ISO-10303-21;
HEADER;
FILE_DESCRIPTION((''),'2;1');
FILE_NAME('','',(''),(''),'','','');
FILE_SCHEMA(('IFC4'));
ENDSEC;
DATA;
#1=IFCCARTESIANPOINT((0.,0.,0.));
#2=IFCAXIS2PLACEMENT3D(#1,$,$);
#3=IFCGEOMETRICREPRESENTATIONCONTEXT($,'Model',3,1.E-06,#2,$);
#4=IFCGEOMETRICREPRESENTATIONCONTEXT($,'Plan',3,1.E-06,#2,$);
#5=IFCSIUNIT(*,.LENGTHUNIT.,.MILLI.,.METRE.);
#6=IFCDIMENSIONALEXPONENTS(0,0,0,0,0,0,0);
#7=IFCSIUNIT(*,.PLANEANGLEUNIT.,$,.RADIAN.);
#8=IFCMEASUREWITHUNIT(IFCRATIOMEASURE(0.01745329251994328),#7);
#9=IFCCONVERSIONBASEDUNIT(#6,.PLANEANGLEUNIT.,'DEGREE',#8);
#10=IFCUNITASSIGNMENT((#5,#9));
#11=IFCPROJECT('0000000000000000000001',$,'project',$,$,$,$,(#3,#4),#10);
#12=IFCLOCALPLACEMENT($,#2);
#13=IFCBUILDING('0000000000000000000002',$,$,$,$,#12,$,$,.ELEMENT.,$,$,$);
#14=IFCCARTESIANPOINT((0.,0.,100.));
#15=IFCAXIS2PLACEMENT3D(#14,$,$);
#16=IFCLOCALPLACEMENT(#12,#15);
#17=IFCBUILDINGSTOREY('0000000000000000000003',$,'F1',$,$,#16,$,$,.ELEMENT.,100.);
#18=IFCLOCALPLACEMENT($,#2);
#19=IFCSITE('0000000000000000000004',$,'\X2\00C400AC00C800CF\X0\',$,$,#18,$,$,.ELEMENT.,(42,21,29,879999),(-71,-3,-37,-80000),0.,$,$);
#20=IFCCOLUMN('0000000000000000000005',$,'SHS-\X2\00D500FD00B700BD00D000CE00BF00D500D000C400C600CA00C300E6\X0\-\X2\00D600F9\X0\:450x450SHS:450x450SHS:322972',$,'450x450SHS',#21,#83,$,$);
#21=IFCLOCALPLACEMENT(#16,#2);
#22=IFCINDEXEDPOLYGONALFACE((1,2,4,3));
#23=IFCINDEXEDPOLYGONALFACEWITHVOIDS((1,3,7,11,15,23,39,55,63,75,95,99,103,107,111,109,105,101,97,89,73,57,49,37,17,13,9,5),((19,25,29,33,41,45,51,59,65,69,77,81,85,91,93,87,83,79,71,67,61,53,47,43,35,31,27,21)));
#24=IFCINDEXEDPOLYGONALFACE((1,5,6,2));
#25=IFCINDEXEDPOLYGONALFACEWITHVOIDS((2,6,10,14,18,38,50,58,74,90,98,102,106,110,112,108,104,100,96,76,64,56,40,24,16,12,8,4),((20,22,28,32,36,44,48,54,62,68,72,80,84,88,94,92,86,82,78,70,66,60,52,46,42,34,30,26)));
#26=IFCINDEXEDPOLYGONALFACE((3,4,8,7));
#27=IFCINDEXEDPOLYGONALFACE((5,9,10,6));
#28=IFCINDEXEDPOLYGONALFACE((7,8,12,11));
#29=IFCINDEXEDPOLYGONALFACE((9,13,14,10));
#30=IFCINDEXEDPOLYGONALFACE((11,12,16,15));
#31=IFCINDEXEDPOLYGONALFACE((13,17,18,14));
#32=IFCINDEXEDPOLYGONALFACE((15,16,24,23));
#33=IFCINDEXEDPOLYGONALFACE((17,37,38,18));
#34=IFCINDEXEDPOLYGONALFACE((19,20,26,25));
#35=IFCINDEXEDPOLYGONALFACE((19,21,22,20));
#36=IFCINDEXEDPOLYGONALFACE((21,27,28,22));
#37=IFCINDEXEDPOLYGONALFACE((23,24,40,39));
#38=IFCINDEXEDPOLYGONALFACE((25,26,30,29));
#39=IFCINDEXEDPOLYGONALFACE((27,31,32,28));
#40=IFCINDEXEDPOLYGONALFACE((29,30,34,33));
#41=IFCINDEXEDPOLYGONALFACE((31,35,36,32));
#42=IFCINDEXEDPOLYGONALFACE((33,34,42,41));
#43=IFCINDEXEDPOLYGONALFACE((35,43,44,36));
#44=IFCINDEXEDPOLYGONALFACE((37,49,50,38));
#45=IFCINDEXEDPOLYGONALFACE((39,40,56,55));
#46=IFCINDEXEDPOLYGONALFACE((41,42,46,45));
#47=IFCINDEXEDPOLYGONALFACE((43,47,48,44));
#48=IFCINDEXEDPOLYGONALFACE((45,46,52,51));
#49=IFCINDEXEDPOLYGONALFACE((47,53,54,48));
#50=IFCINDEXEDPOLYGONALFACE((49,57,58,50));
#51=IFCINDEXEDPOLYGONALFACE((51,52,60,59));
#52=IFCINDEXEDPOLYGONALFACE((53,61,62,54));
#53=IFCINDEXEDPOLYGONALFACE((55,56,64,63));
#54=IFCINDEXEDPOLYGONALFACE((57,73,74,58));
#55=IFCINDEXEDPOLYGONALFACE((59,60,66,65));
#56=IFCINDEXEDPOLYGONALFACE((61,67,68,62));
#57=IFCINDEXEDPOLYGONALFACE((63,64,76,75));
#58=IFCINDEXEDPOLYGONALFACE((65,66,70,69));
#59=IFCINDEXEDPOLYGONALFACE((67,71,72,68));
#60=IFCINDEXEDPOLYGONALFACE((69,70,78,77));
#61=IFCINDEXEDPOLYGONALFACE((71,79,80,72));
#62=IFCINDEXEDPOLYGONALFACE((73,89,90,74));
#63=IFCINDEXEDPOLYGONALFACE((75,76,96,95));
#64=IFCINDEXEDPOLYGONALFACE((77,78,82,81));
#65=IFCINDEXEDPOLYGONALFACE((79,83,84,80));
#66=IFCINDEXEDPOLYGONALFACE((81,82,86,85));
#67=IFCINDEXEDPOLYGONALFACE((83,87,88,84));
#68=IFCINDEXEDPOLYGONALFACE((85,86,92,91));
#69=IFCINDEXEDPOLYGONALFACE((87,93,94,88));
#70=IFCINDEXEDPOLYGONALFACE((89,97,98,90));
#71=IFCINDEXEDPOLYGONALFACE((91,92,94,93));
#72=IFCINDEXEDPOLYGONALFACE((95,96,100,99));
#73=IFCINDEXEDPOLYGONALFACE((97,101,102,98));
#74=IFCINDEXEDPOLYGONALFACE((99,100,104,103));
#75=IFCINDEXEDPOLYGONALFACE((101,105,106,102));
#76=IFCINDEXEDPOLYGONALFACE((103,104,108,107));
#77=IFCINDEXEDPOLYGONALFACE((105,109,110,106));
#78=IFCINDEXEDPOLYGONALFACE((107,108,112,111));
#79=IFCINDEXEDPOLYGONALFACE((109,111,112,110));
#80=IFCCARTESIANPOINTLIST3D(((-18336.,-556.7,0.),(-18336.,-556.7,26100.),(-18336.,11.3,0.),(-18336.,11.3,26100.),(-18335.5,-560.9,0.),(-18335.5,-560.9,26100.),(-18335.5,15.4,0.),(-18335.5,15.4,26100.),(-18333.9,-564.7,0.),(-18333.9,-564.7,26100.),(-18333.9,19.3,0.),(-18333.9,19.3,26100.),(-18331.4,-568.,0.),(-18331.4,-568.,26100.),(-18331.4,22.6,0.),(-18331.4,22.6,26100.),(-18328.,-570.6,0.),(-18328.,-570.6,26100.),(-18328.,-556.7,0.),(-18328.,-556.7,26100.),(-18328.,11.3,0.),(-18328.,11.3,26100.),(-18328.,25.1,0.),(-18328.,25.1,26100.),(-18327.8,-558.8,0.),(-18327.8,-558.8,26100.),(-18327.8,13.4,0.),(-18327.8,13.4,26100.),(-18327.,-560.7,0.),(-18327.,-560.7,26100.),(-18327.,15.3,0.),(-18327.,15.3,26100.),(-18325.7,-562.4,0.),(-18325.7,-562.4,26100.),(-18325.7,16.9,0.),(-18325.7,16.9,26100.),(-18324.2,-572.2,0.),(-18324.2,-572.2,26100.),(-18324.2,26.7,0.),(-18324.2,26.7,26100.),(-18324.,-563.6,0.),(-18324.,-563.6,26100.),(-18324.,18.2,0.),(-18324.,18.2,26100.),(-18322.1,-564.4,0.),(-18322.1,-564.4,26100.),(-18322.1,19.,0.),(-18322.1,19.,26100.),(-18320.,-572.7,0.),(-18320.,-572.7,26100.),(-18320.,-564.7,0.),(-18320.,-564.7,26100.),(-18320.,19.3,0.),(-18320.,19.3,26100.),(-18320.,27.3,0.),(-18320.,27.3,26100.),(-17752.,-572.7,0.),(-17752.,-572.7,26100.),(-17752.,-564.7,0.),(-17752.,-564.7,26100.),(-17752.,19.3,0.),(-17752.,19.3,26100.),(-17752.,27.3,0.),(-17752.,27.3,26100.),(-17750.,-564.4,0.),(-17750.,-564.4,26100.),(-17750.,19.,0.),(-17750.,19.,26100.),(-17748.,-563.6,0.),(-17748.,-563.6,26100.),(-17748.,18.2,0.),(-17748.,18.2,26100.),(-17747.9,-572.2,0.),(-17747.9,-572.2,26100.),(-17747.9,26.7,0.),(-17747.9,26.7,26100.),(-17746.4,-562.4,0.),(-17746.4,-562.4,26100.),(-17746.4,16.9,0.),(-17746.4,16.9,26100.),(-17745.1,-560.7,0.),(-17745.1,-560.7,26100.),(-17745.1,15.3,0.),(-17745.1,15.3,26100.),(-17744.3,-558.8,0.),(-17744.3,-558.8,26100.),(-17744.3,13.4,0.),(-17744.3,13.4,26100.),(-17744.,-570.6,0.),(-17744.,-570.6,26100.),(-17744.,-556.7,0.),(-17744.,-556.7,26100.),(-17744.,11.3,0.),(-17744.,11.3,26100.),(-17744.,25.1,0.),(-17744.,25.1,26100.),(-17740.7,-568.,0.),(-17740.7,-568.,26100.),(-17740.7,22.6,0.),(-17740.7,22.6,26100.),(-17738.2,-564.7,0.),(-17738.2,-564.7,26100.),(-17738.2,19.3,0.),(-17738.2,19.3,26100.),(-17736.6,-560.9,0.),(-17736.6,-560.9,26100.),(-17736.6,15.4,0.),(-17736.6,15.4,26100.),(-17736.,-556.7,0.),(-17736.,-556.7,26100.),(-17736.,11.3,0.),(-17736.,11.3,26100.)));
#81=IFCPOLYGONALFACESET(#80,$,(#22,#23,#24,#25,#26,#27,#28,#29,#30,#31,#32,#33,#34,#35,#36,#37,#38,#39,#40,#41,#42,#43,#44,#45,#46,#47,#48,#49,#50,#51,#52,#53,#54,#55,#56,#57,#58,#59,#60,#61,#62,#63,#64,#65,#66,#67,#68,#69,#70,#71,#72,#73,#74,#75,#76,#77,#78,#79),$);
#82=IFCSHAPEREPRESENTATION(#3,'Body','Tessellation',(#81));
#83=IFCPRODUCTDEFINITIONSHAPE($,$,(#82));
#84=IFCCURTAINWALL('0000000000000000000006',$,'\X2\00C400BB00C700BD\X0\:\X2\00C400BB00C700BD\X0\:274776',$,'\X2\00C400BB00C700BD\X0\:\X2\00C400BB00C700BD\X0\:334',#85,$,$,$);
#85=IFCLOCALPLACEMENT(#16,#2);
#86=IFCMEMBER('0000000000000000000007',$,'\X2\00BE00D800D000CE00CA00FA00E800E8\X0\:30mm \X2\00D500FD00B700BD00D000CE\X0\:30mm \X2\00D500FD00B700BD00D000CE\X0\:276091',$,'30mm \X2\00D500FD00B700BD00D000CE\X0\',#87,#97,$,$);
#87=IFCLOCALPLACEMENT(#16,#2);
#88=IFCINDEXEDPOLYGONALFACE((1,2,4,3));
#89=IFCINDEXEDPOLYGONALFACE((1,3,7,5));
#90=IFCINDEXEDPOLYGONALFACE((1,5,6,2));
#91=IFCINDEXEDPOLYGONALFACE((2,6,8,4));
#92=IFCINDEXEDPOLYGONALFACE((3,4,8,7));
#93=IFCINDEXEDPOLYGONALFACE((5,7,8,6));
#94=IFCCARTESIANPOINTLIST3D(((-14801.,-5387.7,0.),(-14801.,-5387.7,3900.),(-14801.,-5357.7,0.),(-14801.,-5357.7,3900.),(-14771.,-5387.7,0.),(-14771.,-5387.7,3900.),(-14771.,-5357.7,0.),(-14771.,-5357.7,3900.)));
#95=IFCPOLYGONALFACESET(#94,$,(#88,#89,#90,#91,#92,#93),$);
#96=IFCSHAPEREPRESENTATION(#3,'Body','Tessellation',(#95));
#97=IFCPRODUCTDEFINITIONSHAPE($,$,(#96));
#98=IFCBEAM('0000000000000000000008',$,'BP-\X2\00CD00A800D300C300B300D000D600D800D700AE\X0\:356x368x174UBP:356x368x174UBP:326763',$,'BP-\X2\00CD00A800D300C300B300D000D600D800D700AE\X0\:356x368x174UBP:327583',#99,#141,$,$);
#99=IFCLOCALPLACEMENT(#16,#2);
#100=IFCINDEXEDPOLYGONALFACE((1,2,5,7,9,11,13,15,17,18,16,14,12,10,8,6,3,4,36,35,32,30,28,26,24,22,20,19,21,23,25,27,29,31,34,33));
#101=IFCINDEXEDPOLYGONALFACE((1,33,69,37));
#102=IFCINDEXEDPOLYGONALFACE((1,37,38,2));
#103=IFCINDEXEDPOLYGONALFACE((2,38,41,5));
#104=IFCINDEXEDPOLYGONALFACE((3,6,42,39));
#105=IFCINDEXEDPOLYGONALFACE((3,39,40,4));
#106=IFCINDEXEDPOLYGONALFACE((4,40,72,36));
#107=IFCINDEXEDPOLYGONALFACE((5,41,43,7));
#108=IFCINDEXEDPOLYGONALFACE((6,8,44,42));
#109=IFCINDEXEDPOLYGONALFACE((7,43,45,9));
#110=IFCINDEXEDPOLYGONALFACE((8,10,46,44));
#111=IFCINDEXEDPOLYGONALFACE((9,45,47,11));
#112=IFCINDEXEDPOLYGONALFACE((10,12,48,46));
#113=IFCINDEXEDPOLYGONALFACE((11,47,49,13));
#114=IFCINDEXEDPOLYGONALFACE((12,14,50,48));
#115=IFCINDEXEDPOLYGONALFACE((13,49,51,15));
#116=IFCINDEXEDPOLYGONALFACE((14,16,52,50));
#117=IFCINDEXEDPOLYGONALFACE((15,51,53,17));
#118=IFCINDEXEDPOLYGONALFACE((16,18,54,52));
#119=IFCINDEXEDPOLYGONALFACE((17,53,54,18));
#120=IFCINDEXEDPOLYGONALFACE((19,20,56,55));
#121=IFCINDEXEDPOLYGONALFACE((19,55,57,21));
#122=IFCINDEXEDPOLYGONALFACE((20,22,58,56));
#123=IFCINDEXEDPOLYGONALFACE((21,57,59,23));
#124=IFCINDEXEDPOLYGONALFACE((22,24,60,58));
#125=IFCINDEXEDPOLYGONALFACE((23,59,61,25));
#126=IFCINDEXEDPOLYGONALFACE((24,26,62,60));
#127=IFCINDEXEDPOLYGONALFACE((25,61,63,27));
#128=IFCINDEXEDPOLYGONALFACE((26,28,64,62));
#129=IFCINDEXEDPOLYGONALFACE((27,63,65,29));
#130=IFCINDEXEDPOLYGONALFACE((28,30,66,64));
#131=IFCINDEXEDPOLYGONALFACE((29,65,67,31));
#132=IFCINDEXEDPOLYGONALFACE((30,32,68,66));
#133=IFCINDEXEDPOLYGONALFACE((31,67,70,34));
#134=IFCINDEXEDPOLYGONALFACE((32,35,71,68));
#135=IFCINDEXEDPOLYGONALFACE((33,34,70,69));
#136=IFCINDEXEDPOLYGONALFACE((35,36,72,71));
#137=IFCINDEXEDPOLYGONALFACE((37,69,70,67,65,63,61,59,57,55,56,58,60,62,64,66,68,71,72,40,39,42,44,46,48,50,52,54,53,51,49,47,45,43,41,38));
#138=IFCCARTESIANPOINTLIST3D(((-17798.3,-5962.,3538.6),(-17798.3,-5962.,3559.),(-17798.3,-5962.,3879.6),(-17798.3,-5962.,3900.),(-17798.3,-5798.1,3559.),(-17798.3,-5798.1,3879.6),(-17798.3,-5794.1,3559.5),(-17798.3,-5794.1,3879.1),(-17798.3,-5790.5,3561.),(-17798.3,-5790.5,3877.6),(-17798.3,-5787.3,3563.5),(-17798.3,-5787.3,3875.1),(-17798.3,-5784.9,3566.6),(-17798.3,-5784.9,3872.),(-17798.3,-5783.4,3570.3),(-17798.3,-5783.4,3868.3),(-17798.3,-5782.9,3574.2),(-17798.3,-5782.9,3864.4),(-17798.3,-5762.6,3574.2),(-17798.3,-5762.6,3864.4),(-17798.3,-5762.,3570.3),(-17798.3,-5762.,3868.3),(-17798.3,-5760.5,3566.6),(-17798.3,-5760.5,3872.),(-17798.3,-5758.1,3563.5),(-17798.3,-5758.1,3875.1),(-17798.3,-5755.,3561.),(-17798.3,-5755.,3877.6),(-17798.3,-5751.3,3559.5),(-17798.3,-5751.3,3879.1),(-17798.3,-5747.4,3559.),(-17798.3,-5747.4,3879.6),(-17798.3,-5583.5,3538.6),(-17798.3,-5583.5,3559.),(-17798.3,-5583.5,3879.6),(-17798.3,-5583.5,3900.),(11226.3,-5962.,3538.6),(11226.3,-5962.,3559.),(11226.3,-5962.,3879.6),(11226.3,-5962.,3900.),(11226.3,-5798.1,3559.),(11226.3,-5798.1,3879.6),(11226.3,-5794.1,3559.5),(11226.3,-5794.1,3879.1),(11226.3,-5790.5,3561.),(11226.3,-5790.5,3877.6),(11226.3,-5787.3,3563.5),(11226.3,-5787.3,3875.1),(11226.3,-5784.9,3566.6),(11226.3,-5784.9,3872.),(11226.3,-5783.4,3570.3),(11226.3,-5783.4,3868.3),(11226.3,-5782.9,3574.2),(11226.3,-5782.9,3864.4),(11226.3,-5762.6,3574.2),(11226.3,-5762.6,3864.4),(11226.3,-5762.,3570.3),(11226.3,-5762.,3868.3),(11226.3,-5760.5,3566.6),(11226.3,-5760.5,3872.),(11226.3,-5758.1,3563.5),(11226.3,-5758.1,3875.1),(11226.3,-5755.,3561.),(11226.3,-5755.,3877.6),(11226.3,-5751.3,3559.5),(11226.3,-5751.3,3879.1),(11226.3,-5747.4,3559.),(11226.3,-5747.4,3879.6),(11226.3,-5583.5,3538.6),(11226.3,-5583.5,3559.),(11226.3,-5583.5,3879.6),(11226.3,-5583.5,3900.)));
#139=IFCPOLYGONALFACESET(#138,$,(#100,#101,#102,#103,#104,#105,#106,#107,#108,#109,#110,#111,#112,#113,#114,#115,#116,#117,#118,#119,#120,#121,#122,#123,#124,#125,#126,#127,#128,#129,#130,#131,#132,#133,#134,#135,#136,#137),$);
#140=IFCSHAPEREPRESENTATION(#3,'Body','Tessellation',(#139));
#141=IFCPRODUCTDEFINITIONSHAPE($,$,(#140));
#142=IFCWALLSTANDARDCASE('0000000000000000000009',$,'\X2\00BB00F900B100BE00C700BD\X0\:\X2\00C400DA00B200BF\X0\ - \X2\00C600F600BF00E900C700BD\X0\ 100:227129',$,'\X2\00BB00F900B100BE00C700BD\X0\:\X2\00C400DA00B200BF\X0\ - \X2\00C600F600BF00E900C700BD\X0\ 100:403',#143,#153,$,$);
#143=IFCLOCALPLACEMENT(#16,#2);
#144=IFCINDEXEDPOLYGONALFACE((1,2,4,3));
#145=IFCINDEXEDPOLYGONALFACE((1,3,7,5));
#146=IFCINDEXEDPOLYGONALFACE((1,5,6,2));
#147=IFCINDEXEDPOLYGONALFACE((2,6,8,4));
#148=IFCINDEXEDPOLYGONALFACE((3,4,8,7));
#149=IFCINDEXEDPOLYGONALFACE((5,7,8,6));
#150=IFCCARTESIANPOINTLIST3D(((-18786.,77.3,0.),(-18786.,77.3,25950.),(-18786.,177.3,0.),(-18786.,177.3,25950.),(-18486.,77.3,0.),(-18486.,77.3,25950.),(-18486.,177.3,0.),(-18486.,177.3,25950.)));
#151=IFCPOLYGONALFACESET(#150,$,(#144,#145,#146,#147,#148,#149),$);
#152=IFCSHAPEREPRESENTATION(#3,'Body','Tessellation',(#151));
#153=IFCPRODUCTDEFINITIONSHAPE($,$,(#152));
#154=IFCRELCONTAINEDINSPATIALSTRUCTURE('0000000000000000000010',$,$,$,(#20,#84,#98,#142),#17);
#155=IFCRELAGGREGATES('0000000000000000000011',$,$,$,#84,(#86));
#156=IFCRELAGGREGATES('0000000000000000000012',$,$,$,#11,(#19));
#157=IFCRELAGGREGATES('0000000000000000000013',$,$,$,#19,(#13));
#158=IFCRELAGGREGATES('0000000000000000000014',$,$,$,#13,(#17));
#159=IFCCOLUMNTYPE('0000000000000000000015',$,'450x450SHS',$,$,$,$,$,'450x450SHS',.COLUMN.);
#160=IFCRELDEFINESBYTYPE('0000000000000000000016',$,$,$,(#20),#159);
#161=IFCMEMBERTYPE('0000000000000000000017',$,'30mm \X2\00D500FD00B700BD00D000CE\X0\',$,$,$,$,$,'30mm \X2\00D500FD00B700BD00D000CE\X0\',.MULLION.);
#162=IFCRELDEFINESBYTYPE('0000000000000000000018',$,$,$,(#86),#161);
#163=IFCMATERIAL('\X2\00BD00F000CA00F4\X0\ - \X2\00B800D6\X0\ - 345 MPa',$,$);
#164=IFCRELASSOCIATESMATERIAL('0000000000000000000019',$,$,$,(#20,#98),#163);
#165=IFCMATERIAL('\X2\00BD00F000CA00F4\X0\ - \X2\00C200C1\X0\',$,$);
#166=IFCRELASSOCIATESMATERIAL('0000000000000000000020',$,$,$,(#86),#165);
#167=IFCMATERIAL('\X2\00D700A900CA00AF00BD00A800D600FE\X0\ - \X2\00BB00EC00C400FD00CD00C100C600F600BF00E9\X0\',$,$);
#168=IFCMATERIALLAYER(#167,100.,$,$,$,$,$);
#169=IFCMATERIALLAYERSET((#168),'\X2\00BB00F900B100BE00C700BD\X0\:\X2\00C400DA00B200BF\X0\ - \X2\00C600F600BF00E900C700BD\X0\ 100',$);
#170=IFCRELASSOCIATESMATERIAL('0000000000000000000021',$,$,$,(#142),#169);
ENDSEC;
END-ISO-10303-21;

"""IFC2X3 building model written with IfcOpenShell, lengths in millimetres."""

from ifc_helpers import new_model, entity, si_unit, converted_unit, frame, frame_2d, origin, origin_2d_with_axis, place, context, project, spatial, polyline, circle_curve, parameter, trimmed, segment, composite_curve, rectangle, outline, extrude, clip, bounded_halfspace, source, transform, mapped, material, layer, layer_set, layer_usage, type_object, type_shapes, element, aggregate, save


model = new_model("IFC2X3")

# Units and contexts
model_context = context("Model", 3, precision=1e-06, world=origin())
plan_context = context("Plan", 3, precision=1e-06, world=origin())
ifc_project = project(units=[si_unit("LENGTHUNIT", "METRE", prefix="MILLI"), converted_unit("PLANEANGLEUNIT", "DEGREE", entity("IfcRatioMeasure", 0.01745329251994328), si_unit("PLANEANGLEUNIT", "RADIAN"), dimensions=[0, 0, 0, 0, 0, 0, 0])], contexts=[model_context, plan_context])

# Site, building, storey
site_placement = place(None, origin())
site = spatial("IfcSite", under=ifc_project, at=site_placement, Name="Ä¬ÈÏ", CompositionType="ELEMENT", RefLatitude=(42, 21, 29, 879999), RefLongitude=(-71, -3, -37, -80000), RefElevation=0.0)
building_placement = place(None, origin())
building = spatial("IfcBuilding", under=site, at=building_placement, CompositionType="ELEMENT")
storey_placement = place(building_placement, frame((0.0, 0.0, 100.0)))
storey = spatial("IfcBuildingStorey", under=building, at=storey_placement, Name="F1", CompositionType="ELEMENT", Elevation=100.0)

# Column
ifc_material_1 = material(Name="½ðÊô - ¸Ö - 345 MPa")
column_type_1 = type_object("IfcColumnType", Name="450x450SHS", ElementType="450x450SHS", PredefinedType="COLUMN")
shared_shape_1 = source(origin(), model_context, "Body", "SweptSolid", [
    extrude(outline(composite_curve([segment(polyline([(-284.0, -300.0), (284.0, -300.0)]), True, "CONTINUOUS"), segment(trimmed(circle_curve(frame_2d((284.0, -284.0), x_axis=(-1.0, 0.0)), 16.0), [parameter(90.0)], [parameter(180.0)], True, "PARAMETER"), True, "CONTINUOUS"), segment(polyline([(300.0, -284.0), (300.0, 284.0)]), True, "CONTINUOUS"), segment(trimmed(circle_curve(frame_2d((284.0, 284.0), x_axis=(-1.0, 0.0)), 16.0), [parameter(180.0)], [parameter(270.0)], True, "PARAMETER"), True, "CONTINUOUS"), segment(polyline([(284.0, 300.0), (-284.0, 300.0)]), True, "CONTINUOUS"), segment(trimmed(circle_curve(frame_2d((-284.0, 284.0), x_axis=(-1.0, 0.0)), 16.0), [parameter(270.0)], [parameter(360.0)], True, "PARAMETER"), True, "CONTINUOUS"), segment(polyline([(-300.0, 284.0), (-300.0, -284.0)]), True, "CONTINUOUS"), segment(trimmed(circle_curve(frame_2d((-284.0, -284.0), x_axis=(-1.0, 0.0)), 16.0), [parameter(360.0)], [parameter(90.0)], True, "PARAMETER"), True, "CONTINUOUS")], self_intersect=False), holes=[composite_curve([segment(trimmed(circle_curve(frame_2d((-284.0, -284.0), x_axis=(-1.0, 0.0)), 8.0), [parameter(0.0)], [parameter(90.0)], True, "PARAMETER"), False, "CONTINUOUS"), segment(polyline([(-292.0, -284.0), (-292.0, 284.0)]), True, "CONTINUOUS"), segment(trimmed(circle_curve(frame_2d((-284.0, 284.0), x_axis=(-1.0, 0.0)), 8.0), [parameter(270.0)], [parameter(360.0)], True, "PARAMETER"), False, "CONTINUOUS"), segment(polyline([(-284.0, 292.0), (284.0, 292.0)]), True, "CONTINUOUS"), segment(trimmed(circle_curve(frame_2d((284.0, 284.0), x_axis=(-1.0, 0.0)), 8.0), [parameter(180.0)], [parameter(270.0)], True, "PARAMETER"), False, "CONTINUOUS"), segment(polyline([(292.0, 284.0), (292.0, -284.0)]), True, "CONTINUOUS"), segment(trimmed(circle_curve(frame_2d((284.0, -284.0), x_axis=(-1.0, 0.0)), 8.0), [parameter(90.0)], [parameter(180.0)], True, "PARAMETER"), False, "CONTINUOUS"), segment(polyline([(284.0, -292.0), (-284.0, -292.0)]), True, "CONTINUOUS")], self_intersect=False)]), frame((0.0, 0.0, 100.0), z_axis=(0.0, 0.0, 1.0), x_axis=(-1.0, 0.0, 0.0)), (0.0, 0.0, 1.0), 26100.0),
])
type_shapes(column_type_1, [shared_shape_1])
for number, where, name in (
    (1, (-18036.0, -272.7, -100.0), "SHS-Õý·½ÐÎ¿ÕÐÄÆÊÃæ-Öù:450x450SHS:450x450SHS:322972"),
):
    element("IfcColumn", number, at=place(storey_placement, frame(where)), inside=storey, type_object=column_type_1, material=ifc_material_1, Name=name, ObjectType="450x450SHS", context=model_context, shape_type="MappedRepresentation", body=[
        mapped(shared_shape_1, transform((0.0, 0.0, 0.0), scale=1.0)),
    ])

# Curtain wall, member
curtain_wall_1_placement = place(storey_placement, origin())
curtain_wall_1 = element("IfcCurtainWall", 2, at=curtain_wall_1_placement, inside=storey, Name="Ä»Ç½:Ä»Ç½:274776", ObjectType="Ä»Ç½:Ä»Ç½:334")
ifc_material_2 = material(Name="½ðÊô - ÂÁ")
member_type = type_object("IfcMemberType", Name="30mm Õý·½ÐÎ", ElementType="30mm Õý·½ÐÎ", PredefinedType="MULLION")
shared_shape_2 = source(origin(), model_context, "Body", "SweptSolid", [
    extrude(rectangle(XDim=30.0, YDim=30.0, at=origin_2d_with_axis()), frame((0.0, 0.0, -3900.0), z_axis=(0.0, 0.0, 1.0), x_axis=(-1.0, 0.0, 0.0)), (0.0, 0.0, 1.0), 3900.0),
])
type_shapes(member_type, [shared_shape_2])
member_placement = place(storey_placement, frame((-14786.0, -5372.7, 0.0), z_axis=(0.0, 0.0, -1.0), x_axis=(1.0, 0.0, 0.0)))
member = element("IfcMember", 3, at=member_placement, type_object=member_type, material=ifc_material_2, Name="¾ØÐÎÊúèè:30mm Õý·½ÐÎ:30mm Õý·½ÐÎ:276091", ObjectType="30mm Õý·½ÐÎ", context=model_context, shape_type="MappedRepresentation", body=[
    mapped(shared_shape_2, transform((0.0, 0.0, 0.0), scale=1.0)),
])

# Beam
beam_1_placement = place(storey_placement, frame((-18036.0, -5772.7, 3900.0), z_axis=(0.0, 0.0, 1.0), x_axis=(0.0, -1.0, 0.0)))
element("IfcBeam", 4, at=beam_1_placement, inside=storey, material=ifc_material_1, Name="BP-Í¨ÓÃ³ÐÖØ×®:356x368x174UBP:356x368x174UBP:326763", ObjectType="BP-Í¨ÓÃ³ÐÖØ×®:356x368x174UBP:327583", context=model_context, shape_type="SweptSolid", body=[
    extrude(outline(composite_curve([segment(polyline([(-189.2, -160.3), (-189.2, -180.7)]), True, "CONTINUOUS"), segment(polyline([(-189.2, -180.7), (189.3, -180.7)]), True, "CONTINUOUS"), segment(polyline([(189.3, -180.7), (189.3, -160.3)]), True, "CONTINUOUS"), segment(polyline([(189.3, -160.3), (25.4, -160.3)]), True, "CONTINUOUS"), segment(trimmed(circle_curve(frame_2d((25.4, -145.1), x_axis=(1.0, 0.0)), 15.2), [parameter(180.0)], [parameter(270.0)], True, "PARAMETER"), False, "CONTINUOUS"), segment(polyline([(10.2, -145.1), (10.2, 145.1)]), True, "CONTINUOUS"), segment(trimmed(circle_curve(frame_2d((25.4, 145.1), x_axis=(1.0, 0.0)), 15.2), [parameter(90.0)], [parameter(180.0)], True, "PARAMETER"), False, "CONTINUOUS"), segment(polyline([(25.4, 160.3), (189.3, 160.3)]), True, "CONTINUOUS"), segment(polyline([(189.3, 160.3), (189.3, 180.7)]), True, "CONTINUOUS"), segment(polyline([(189.3, 180.7), (-189.2, 180.7)]), True, "CONTINUOUS"), segment(polyline([(-189.2, 180.7), (-189.2, 160.3)]), True, "CONTINUOUS"), segment(polyline([(-189.2, 160.3), (-25.3, 160.3)]), True, "CONTINUOUS"), segment(trimmed(circle_curve(frame_2d((-25.3, 145.1), x_axis=(1.0, 0.0)), 15.2), [parameter(360.0)], [parameter(90.0)], True, "PARAMETER"), False, "CONTINUOUS"), segment(polyline([(-10.1, 145.1), (-10.1, -145.1)]), True, "CONTINUOUS"), segment(trimmed(circle_curve(frame_2d((-25.3, -145.1), x_axis=(1.0, 0.0)), 15.2), [parameter(270.0)], [parameter(360.0)], True, "PARAMETER"), False, "CONTINUOUS"), segment(polyline([(-25.3, -160.3), (-189.2, -160.3)]), True, "CONTINUOUS")], self_intersect=False)), frame((0.0, 237.7, -180.7), z_axis=(0.0, -1.0, 0.0), x_axis=(1.0, 0.0, 0.0)), (0.0, 0.0, -1.0), 29024.6),
])

aggregate(curtain_wall_1, [member])

# Wall
ifc_material_3 = material(Name="×©Ê¯½¨Öþ - »ìÄýÍÁÆö¿é")
ifc_layer = layer(ifc_material_3, 100.0)
ifc_layer_set = layer_set([ifc_layer], Name="»ù±¾Ç½:ÄÚ²¿ - Æö¿éÇ½ 100")
ifc_layer_usage = layer_usage(ifc_layer_set, "AXIS2", "NEGATIVE", 50.0)
wall_placement = place(storey_placement, frame((-18486.0, 127.3, 0.0), z_axis=(0.0, 0.0, 1.0), x_axis=(-1.0, 0.0, 0.0)))
element("IfcWallStandardCase", 5, at=wall_placement, inside=storey, material=ifc_layer_usage, Name="»ù±¾Ç½:ÄÚ²¿ - Æö¿éÇ½ 100:227129", ObjectType="»ù±¾Ç½:ÄÚ²¿ - Æö¿éÇ½ 100:403", context=model_context, shape_type="Clipping", body=[
    clip(extrude(rectangle(XDim=300.0, YDim=100.0, at=frame_2d((150.0, 0.0), x_axis=(-1.0, 0.0))), origin(), (0.0, 0.0, 1.0), 25950.0), bounded_halfspace(frame((0.0, -50.0, 25950.0), z_axis=(0.0, 0.0, -1.0), x_axis=(-1.0, 0.0, 0.0)), True, frame((0.0, -50.0, 25950.0)), polyline([(0.0, 0.0), (200.0, 0.0), (300.0, 0.0), (300.0, 100.0), (0.0, 100.0), (0.0, 0.0)]))),
])

save(model, "model.ifc")
